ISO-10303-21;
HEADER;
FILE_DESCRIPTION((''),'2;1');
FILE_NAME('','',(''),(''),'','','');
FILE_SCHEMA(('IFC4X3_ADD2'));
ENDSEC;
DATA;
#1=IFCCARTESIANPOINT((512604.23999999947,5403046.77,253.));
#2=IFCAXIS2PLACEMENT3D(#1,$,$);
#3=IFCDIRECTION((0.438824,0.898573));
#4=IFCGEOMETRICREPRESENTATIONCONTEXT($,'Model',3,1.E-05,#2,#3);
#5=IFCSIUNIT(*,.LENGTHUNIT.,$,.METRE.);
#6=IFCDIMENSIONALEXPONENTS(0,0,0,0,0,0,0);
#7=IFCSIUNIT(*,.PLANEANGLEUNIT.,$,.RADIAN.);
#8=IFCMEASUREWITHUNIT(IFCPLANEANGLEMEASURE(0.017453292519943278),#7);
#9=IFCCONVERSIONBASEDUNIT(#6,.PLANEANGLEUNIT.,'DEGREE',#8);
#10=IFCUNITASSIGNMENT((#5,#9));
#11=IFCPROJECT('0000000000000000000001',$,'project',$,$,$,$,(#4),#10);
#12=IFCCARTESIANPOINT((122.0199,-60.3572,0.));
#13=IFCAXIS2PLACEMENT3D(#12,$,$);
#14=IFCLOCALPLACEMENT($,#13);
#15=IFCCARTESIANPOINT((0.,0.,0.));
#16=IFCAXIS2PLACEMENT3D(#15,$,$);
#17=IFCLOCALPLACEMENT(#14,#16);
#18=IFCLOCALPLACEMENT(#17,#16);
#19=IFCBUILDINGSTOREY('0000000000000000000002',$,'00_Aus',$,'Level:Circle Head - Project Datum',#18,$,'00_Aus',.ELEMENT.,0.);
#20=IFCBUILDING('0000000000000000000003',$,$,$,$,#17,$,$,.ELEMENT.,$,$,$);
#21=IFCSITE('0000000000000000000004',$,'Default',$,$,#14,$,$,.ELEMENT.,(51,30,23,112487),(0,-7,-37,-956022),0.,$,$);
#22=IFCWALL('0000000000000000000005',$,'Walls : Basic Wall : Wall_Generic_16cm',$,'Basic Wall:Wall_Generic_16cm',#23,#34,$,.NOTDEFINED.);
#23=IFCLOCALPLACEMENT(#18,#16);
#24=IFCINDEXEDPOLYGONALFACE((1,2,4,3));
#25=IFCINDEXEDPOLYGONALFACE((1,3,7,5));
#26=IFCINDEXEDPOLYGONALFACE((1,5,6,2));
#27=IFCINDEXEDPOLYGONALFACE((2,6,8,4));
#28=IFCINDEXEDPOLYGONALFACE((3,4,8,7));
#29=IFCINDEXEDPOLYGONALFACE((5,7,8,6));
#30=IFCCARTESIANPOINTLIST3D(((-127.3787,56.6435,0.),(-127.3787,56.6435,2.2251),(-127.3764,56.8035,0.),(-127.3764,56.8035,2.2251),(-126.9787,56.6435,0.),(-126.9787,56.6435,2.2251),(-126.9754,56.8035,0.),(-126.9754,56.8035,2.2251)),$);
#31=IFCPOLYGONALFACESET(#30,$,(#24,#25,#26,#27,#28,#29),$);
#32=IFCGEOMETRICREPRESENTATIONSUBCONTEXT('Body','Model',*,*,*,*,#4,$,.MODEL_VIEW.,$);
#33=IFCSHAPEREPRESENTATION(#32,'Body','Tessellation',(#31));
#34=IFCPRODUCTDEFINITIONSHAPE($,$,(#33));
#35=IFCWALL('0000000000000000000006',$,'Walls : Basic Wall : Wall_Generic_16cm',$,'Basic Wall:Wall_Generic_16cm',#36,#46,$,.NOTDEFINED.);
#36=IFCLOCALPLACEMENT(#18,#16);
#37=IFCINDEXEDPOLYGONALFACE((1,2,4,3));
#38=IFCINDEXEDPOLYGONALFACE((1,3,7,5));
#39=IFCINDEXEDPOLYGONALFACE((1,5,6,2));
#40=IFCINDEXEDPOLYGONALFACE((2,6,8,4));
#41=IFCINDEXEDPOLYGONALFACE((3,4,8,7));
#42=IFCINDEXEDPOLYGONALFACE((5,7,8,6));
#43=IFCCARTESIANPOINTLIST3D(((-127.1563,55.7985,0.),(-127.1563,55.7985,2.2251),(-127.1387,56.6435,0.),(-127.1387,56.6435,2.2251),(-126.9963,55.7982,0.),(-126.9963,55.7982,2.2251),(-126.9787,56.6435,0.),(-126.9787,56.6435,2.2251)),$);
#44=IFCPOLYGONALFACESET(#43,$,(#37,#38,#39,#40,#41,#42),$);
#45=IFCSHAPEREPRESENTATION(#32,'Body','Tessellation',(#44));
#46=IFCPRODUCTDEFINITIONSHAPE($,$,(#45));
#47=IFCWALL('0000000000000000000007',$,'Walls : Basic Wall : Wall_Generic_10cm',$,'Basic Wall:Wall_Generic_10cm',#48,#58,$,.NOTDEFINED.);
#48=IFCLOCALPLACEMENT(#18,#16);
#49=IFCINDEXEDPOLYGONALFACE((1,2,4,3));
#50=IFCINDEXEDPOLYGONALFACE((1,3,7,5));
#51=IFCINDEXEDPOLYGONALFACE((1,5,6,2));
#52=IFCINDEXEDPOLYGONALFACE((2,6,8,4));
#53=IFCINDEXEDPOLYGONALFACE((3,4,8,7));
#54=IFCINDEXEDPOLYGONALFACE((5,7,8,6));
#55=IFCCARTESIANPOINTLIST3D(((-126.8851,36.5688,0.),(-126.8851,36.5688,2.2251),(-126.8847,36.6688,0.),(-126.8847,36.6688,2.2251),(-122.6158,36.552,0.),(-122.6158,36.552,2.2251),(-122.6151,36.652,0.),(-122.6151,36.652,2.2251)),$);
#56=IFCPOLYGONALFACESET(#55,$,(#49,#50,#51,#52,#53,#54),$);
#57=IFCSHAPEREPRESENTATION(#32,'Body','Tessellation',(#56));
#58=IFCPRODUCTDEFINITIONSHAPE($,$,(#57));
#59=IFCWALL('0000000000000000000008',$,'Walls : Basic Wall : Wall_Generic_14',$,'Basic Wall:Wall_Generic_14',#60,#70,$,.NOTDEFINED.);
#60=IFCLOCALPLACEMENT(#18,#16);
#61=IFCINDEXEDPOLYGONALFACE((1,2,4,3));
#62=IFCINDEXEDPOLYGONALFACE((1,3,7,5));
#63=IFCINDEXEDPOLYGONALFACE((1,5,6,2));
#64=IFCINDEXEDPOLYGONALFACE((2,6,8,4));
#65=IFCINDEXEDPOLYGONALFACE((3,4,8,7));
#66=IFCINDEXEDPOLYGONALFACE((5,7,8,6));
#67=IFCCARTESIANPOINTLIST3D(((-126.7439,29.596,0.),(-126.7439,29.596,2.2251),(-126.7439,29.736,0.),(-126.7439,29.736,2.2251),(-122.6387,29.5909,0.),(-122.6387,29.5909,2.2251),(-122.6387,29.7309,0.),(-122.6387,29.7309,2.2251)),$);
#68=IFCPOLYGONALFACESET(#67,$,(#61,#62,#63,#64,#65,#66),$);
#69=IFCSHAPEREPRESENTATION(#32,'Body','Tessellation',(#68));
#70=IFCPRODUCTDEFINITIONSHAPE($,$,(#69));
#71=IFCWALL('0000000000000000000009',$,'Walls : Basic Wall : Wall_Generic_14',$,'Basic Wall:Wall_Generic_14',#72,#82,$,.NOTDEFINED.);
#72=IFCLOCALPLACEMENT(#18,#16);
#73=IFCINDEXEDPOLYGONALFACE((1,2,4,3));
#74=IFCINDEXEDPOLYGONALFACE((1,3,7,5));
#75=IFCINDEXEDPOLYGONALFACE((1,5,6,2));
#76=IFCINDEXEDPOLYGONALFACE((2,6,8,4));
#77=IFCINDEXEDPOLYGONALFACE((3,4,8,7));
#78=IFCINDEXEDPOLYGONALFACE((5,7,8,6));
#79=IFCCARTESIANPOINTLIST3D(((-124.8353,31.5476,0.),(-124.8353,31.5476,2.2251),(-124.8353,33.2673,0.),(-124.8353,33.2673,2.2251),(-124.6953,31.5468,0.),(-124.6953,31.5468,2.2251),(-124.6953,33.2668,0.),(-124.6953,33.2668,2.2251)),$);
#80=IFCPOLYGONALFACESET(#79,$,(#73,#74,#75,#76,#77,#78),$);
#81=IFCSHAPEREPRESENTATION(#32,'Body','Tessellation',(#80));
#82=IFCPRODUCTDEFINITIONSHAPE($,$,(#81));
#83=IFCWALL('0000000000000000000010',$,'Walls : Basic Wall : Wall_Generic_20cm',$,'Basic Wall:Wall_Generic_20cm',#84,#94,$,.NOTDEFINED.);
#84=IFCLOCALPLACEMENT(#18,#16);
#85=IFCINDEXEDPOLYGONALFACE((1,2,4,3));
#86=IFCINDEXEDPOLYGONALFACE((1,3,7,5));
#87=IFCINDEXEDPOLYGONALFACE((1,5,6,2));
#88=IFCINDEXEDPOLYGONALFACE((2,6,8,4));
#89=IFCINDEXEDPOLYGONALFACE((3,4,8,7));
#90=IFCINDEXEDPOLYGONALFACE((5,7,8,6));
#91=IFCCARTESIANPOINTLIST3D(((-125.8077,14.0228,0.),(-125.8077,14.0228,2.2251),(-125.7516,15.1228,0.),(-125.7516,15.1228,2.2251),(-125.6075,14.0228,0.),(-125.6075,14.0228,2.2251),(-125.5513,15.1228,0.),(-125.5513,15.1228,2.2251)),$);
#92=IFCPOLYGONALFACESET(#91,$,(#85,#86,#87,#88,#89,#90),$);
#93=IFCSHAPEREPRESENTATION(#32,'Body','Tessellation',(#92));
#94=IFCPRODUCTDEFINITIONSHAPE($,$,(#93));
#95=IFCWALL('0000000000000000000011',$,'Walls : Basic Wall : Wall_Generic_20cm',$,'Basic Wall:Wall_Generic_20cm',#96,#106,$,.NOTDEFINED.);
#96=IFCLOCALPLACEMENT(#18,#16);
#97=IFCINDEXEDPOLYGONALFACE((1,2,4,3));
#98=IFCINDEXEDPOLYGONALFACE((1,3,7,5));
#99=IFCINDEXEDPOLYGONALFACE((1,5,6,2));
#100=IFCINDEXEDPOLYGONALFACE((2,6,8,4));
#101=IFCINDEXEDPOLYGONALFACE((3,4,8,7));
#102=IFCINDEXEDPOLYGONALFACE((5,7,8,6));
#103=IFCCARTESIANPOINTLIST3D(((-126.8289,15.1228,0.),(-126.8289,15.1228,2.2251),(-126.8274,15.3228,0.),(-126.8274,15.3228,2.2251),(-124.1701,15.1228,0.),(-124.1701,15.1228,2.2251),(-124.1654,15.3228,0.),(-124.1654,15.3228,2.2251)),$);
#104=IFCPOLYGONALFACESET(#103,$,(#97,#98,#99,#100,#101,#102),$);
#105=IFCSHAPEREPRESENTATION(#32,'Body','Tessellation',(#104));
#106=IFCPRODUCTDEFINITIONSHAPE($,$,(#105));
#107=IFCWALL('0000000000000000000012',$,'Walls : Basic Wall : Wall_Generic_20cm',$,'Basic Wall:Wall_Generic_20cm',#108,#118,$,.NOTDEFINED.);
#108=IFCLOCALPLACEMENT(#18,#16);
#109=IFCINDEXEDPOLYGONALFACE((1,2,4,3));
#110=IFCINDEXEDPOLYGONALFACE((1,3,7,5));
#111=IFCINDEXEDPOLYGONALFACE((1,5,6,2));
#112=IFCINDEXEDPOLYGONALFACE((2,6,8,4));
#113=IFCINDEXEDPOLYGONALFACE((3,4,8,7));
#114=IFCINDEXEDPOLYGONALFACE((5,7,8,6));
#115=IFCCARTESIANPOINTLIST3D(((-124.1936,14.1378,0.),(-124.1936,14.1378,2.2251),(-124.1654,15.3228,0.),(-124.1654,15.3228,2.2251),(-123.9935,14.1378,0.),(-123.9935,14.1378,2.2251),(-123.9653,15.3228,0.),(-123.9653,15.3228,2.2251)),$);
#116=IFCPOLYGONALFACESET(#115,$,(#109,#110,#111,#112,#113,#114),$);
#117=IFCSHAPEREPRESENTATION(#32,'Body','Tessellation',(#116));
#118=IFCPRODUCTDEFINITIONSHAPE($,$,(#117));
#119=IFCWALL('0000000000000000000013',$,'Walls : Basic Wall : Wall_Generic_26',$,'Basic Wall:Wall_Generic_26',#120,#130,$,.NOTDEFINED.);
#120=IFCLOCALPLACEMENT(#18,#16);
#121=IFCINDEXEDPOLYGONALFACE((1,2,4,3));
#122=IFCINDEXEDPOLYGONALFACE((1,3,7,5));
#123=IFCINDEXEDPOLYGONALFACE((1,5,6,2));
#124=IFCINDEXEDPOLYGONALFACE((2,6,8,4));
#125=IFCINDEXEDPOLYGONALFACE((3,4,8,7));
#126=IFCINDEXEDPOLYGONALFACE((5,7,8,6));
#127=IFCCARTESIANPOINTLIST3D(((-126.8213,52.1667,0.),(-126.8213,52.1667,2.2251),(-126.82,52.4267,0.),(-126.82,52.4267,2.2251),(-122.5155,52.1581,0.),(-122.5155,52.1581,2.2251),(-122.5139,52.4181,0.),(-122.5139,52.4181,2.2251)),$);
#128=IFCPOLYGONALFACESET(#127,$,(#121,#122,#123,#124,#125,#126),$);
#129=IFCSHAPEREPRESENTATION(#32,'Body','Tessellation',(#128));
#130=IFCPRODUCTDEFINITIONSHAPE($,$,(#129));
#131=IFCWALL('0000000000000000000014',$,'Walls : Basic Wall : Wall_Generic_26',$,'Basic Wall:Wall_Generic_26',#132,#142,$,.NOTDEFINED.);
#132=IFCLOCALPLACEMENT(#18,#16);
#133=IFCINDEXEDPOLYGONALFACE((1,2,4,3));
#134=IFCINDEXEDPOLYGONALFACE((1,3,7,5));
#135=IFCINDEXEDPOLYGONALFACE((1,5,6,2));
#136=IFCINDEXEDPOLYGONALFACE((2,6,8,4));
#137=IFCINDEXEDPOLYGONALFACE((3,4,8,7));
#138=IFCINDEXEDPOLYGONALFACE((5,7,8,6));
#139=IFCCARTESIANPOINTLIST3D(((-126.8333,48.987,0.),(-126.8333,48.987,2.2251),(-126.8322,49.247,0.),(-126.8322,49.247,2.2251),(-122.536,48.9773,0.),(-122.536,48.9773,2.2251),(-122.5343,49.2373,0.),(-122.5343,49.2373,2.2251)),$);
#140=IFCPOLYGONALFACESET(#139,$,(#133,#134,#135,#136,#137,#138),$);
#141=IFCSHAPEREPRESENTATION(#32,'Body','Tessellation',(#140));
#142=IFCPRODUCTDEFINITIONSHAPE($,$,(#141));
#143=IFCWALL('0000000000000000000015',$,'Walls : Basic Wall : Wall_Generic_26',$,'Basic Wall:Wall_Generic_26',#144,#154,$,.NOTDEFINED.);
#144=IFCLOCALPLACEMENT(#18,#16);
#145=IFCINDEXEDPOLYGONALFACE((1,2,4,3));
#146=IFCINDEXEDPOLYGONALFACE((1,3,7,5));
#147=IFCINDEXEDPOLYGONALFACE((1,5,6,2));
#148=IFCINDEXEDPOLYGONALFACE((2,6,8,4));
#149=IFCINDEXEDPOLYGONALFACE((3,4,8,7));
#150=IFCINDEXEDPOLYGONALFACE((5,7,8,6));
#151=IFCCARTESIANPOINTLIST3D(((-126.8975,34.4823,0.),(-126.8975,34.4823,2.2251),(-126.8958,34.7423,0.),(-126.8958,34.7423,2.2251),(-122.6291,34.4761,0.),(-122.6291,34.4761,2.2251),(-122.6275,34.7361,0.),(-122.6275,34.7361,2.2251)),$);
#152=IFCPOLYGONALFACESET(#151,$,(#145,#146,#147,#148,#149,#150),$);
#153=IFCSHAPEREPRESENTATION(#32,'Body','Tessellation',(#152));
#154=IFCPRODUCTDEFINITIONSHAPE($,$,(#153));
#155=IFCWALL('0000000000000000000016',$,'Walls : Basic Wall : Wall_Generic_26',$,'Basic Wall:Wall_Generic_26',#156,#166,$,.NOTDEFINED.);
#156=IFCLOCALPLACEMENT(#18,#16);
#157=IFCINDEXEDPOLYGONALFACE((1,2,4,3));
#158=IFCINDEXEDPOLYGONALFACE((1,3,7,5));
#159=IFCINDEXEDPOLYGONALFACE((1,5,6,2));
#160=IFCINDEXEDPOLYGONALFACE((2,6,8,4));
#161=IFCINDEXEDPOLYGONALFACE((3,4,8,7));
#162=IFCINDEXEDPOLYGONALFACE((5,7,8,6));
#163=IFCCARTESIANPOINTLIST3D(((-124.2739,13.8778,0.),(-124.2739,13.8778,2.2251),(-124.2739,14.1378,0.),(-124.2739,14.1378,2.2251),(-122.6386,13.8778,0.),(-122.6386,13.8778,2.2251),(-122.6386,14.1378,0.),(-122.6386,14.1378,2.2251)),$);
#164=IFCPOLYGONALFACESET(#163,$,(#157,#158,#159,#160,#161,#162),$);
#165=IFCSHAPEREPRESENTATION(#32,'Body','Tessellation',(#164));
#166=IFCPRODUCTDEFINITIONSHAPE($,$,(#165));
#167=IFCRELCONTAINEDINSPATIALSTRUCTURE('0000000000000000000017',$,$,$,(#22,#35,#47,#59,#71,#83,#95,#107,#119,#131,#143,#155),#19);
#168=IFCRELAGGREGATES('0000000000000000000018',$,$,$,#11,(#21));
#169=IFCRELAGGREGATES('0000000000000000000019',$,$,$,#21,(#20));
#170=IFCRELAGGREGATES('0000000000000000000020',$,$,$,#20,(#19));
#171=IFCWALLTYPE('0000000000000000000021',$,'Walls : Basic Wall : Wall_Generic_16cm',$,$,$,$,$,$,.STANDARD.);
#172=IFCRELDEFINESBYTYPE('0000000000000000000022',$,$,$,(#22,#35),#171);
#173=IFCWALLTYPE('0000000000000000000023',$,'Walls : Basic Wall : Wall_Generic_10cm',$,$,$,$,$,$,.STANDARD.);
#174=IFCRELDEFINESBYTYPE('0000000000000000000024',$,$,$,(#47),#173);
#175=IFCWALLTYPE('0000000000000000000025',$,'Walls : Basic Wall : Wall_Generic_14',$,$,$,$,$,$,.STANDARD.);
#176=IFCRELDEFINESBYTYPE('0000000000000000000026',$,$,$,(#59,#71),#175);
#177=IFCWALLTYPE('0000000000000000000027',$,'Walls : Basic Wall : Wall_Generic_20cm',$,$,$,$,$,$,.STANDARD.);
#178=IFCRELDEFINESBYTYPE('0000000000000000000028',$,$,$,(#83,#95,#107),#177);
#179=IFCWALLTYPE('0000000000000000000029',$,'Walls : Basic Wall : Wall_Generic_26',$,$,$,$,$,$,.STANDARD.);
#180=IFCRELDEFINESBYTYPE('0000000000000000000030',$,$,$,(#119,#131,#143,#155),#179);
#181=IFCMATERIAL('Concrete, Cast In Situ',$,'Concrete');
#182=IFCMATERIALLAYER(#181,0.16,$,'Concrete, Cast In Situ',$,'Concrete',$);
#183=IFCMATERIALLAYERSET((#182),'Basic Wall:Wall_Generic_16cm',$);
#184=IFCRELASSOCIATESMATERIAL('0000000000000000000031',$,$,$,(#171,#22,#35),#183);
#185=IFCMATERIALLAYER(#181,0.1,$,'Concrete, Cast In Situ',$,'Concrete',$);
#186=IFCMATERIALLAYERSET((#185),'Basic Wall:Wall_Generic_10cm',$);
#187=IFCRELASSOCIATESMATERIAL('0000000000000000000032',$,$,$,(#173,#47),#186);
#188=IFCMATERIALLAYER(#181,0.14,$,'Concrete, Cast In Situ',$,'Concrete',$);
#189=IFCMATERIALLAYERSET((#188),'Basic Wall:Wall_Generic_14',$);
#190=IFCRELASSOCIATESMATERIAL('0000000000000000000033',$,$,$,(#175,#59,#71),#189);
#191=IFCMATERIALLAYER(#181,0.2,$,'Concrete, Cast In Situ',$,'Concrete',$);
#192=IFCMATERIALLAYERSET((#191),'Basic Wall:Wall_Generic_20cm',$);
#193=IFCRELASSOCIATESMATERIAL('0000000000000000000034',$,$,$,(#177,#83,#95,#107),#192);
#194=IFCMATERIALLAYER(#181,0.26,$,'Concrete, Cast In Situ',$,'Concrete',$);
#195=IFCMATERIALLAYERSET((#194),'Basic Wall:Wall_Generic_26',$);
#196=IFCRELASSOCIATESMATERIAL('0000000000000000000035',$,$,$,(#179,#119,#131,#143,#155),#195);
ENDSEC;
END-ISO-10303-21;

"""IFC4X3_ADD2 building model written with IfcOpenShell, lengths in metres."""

from ifc_helpers import new_model, entity, si_unit, converted_unit, direction, frame, origin, place, context, subcontext, project, spatial, polyline, outline, extrude, clip, halfspace, material, layer, layer_set, type_object, element, save


model = new_model("IFC4X3_ADD2")

# Units and contexts
model_context = context("Model", 3, precision=1e-05, world=frame((512604.23999999947, 5403046.77, 253.0)), true_north=direction((0.438824, 0.898573)))
body_context = subcontext(model_context, "Body", "Model", "MODEL_VIEW")
ifc_project = project(units=[si_unit("LENGTHUNIT", "METRE"), converted_unit("PLANEANGLEUNIT", "DEGREE", entity("IfcPlaneAngleMeasure", 0.017453292519943278), si_unit("PLANEANGLEUNIT", "RADIAN"), dimensions=[0, 0, 0, 0, 0, 0, 0])], contexts=[model_context])

# Site, building, storey
site_placement = place(None, frame((122.0199, -60.3572, 0.0)))
site = spatial("IfcSite", under=ifc_project, at=site_placement, Name="Default", CompositionType="ELEMENT", RefLatitude=(51, 30, 23, 112487), RefLongitude=(0, -7, -37, -956022), RefElevation=0.0)
building_placement = place(site_placement, origin())
building = spatial("IfcBuilding", under=site, at=building_placement, CompositionType="ELEMENT")
storey_placement = place(building_placement, origin())
storey = spatial("IfcBuildingStorey", under=building, at=storey_placement, Name="00_Aus", ObjectType="Level:Circle Head - Project Datum", LongName="00_Aus", CompositionType="ELEMENT", Elevation=0.0)

# Shared definitions
ifc_material_1 = material(Name="Concrete, Cast In Situ", Category="Concrete")

# Walls
ifc_layer_1 = layer(ifc_material_1, 0.16, Name="Concrete, Cast In Situ", Category="Concrete")
ifc_layer_set_1 = layer_set([ifc_layer_1], Name="Basic Wall:Wall_Generic_16cm")
wall_type_1 = type_object("IfcWallType", Name="Walls : Basic Wall : Wall_Generic_16cm", PredefinedType="STANDARD", material=ifc_layer_set_1)
wall_1_placement = place(storey_placement, frame((-127.3787, 56.7235, 0.0)))
element("IfcWall", 1, at=wall_1_placement, inside=storey, type_object=wall_type_1, material=ifc_layer_set_1, Name="Walls : Basic Wall : Wall_Generic_16cm", ObjectType="Basic Wall:Wall_Generic_16cm", PredefinedType="NOTDEFINED", context=body_context, shape_type="Clipping", body=[
    clip(extrude(outline(polyline([(0.4, -0.08), (0.4034, 0.08), (0.1623, 0.08), (0.0023, 0.08), (0.0011, -0.0029), (0.0, -0.08), (0.24, -0.08), (0.4, -0.08)])), origin(), (0.0, 0.0, 1.0), 2.2251), halfspace(frame((0.0, 0.0, -0.66)), True)),
])
wall_2_placement = place(storey_placement, frame((-127.0587, 56.6452, 0.0), z_axis=(0.0, 0.0, 1.0), x_axis=(-0.020814, -0.999783, 0.0)))
element("IfcWall", 2, at=wall_2_placement, inside=storey, type_object=wall_type_1, material=ifc_layer_set_1, Name="Walls : Basic Wall : Wall_Generic_16cm", ObjectType="Basic Wall:Wall_Generic_16cm", PredefinedType="NOTDEFINED", context=body_context, shape_type="Clipping", body=[
    clip(extrude(outline(polyline([(0.8485, -0.08), (0.8455, 0.08), (0.0, 0.08), (0.0033, -0.08), (0.8485, -0.08)])), origin(), (0.0, 0.0, 1.0), 2.2251), halfspace(frame((0.0, 0.0, -0.66)), True)),
])
ifc_layer_2 = layer(ifc_material_1, 0.1, Name="Concrete, Cast In Situ", Category="Concrete")
ifc_layer_set_2 = layer_set([ifc_layer_2], Name="Basic Wall:Wall_Generic_10cm")
wall_type_2 = type_object("IfcWallType", Name="Walls : Basic Wall : Wall_Generic_10cm", PredefinedType="STANDARD", material=ifc_layer_set_2)
wall_3_placement = place(storey_placement, frame((-126.8849, 36.6188, 0.0), z_axis=(0.0, 0.0, 1.0), x_axis=(0.999992, -0.003937, 0.0)))
element("IfcWall", 3, at=wall_3_placement, inside=storey, type_object=wall_type_2, material=ifc_layer_set_2, Name="Walls : Basic Wall : Wall_Generic_10cm", ObjectType="Basic Wall:Wall_Generic_10cm", PredefinedType="NOTDEFINED", context=body_context, shape_type="Clipping", body=[
    clip(extrude(outline(polyline([(4.2694, -0.05), (4.2696, 0.05), (0.0, 0.05), (0.0, -0.05), (2.7103, -0.05), (2.8303, -0.05), (4.2694, -0.05)])), origin(), (0.0, 0.0, 1.0), 2.2251), halfspace(frame((0.0, 0.0, -0.66)), True)),
])
ifc_layer_3 = layer(ifc_material_1, 0.14, Name="Concrete, Cast In Situ", Category="Concrete")
ifc_layer_set_3 = layer_set([ifc_layer_3], Name="Basic Wall:Wall_Generic_14")
wall_type_3 = type_object("IfcWallType", Name="Walls : Basic Wall : Wall_Generic_14", PredefinedType="STANDARD", material=ifc_layer_set_3)
wall_4_placement = place(storey_placement, frame((-122.6386, 29.6609, 0.0), z_axis=(0.0, 0.0, 1.0), x_axis=(-0.999999, 0.001241, 0.0)))
element("IfcWall", 4, at=wall_4_placement, inside=storey, type_object=wall_type_3, material=ifc_layer_set_3, Name="Walls : Basic Wall : Wall_Generic_14", ObjectType="Basic Wall:Wall_Generic_14", PredefinedType="NOTDEFINED", context=body_context, shape_type="Clipping", body=[
    clip(extrude(outline(polyline([(4.1054, -0.07), (4.1052, 0.07), (0.0, 0.07), (0.0002, -0.07), (1.0052, -0.07), (1.1652, -0.07), (2.3156, -0.07), (2.3556, -0.07), (4.1054, -0.07)])), origin(), (0.0, 0.0, 1.0), 2.2251), halfspace(frame((0.0, 0.0, -0.66)), True)),
])
wall_5_placement = place(storey_placement, frame((-124.7653, 31.5468, 0.0), z_axis=(0.0, 0.0, 1.0), x_axis=(0.0, 1.0, 0.0)))
element("IfcWall", 5, at=wall_5_placement, inside=storey, type_object=wall_type_3, material=ifc_layer_set_3, Name="Walls : Basic Wall : Wall_Generic_14", ObjectType="Basic Wall:Wall_Generic_14", PredefinedType="NOTDEFINED", context=body_context, shape_type="Clipping", body=[
    clip(extrude(outline(polyline([(1.72, -0.07), (1.7205, 0.07), (1.6005, 0.07), (0.0008, 0.07), (0.0, -0.07), (1.72, -0.07)])), origin(), (0.0, 0.0, 1.0), 2.2251), halfspace(frame((0.0, 0.0, -0.66)), True)),
])
ifc_layer_4 = layer(ifc_material_1, 0.2, Name="Concrete, Cast In Situ", Category="Concrete")
ifc_layer_set_4 = layer_set([ifc_layer_4], Name="Basic Wall:Wall_Generic_20cm")
wall_type_4 = type_object("IfcWallType", Name="Walls : Basic Wall : Wall_Generic_20cm", PredefinedType="STANDARD", material=ifc_layer_set_4)
wall_6_placement = place(storey_placement, frame((-125.7078, 14.0177, 0.0), z_axis=(0.0, 0.0, 1.0), x_axis=(0.050959, 0.998701, 0.0)))
element("IfcWall", 6, at=wall_6_placement, inside=storey, type_object=wall_type_4, material=ifc_layer_set_4, Name="Walls : Basic Wall : Wall_Generic_20cm", ObjectType="Basic Wall:Wall_Generic_20cm", PredefinedType="NOTDEFINED", context=body_context, shape_type="Clipping", body=[
    clip(extrude(outline(polyline([(1.1116, -0.1), (1.1014, 0.1), (0.0, 0.1), (0.0102, -0.1), (0.7375, -0.1), (1.1116, -0.1)])), origin(), (0.0, 0.0, 1.0), 2.2251), halfspace(frame((0.0, 0.0, -0.66)), True)),
])
wall_7_placement = place(storey_placement, frame((-126.8289, 15.2228, 0.0)))
element("IfcWall", 7, at=wall_7_placement, inside=storey, type_object=wall_type_4, material=ifc_layer_set_4, Name="Walls : Basic Wall : Wall_Generic_20cm", ObjectType="Basic Wall:Wall_Generic_20cm", PredefinedType="NOTDEFINED", context=body_context, shape_type="Clipping", body=[
    clip(extrude(outline(polyline([(2.6587, -0.1), (2.6635, 0.1), (0.0015, 0.1), (0.0, -0.1), (1.0773, -0.1), (1.2775, -0.1), (2.6587, -0.1)])), origin(), (0.0, 0.0, 1.0), 2.2251), halfspace(frame((0.0, 0.0, -0.66)), True)),
])
wall_8_placement = place(storey_placement, frame((-124.0653, 15.3252, 0.0), z_axis=(0.0, 0.0, 1.0), x_axis=(-0.023777, -0.999717, 0.0)))
element("IfcWall", 8, at=wall_8_placement, inside=storey, type_object=wall_type_4, material=ifc_layer_set_4, Name="Walls : Basic Wall : Wall_Generic_20cm", ObjectType="Basic Wall:Wall_Generic_20cm", PredefinedType="NOTDEFINED", context=body_context, shape_type="Clipping", body=[
    clip(extrude(outline(polyline([(1.19, -0.1), (1.1853, 0.1), (0.0, 0.1), (0.0048, -0.1), (0.2048, -0.1), (0.5785, -0.1), (1.19, -0.1)])), origin(), (0.0, 0.0, 1.0), 2.2251), halfspace(frame((0.0, 0.0, -0.66)), True)),
])
ifc_layer_5 = layer(ifc_material_1, 0.26, Name="Concrete, Cast In Situ", Category="Concrete")
ifc_layer_set_5 = layer_set([ifc_layer_5], Name="Basic Wall:Wall_Generic_26")
wall_type_5 = type_object("IfcWallType", Name="Walls : Basic Wall : Wall_Generic_26", PredefinedType="STANDARD", material=ifc_layer_set_5)
wall_9_placement = place(storey_placement, frame((-126.8211, 52.2967, 0.0), z_axis=(0.0, 0.0, 1.0), x_axis=(0.999998, -0.002005, 0.0)))
element("IfcWall", 9, at=wall_9_placement, inside=storey, type_object=wall_type_5, material=ifc_layer_set_5, Name="Walls : Basic Wall : Wall_Generic_26", ObjectType="Basic Wall:Wall_Generic_26", PredefinedType="NOTDEFINED", context=body_context, shape_type="Clipping", body=[
    clip(extrude(outline(polyline([(4.3058, -0.13), (4.3069, 0.13), (0.0008, 0.13), (0.0, -0.13), (0.0013, -0.13), (4.3058, -0.13)])), origin(), (0.0, 0.0, 1.0), 2.2251), halfspace(frame((0.0, 0.0, -0.66)), True)),
])
wall_10_placement = place(storey_placement, frame((-122.5346, 49.1073, 0.0), z_axis=(0.0, 0.0, 1.0), x_axis=(-0.999997, 0.002248, 0.0)))
element("IfcWall", 10, at=wall_10_placement, inside=storey, type_object=wall_type_5, material=ifc_layer_set_5, Name="Walls : Basic Wall : Wall_Generic_26", ObjectType="Basic Wall:Wall_Generic_26", PredefinedType="NOTDEFINED", context=body_context, shape_type="Clipping", body=[
    clip(extrude(outline(polyline([(4.298, -0.13), (4.2985, 0.13), (0.0011, 0.13), (0.0, -0.13), (4.298, -0.13)])), origin(), (0.0, 0.0, 1.0), 2.2251), halfspace(frame((0.0, 0.0, -0.66)), True)),
])
wall_11_placement = place(storey_placement, frame((-122.6276, 34.6061, 0.0), z_axis=(0.0, 0.0, 1.0), x_axis=(-0.999999, 0.001453, 0.0)))
element("IfcWall", 11, at=wall_11_placement, inside=storey, type_object=wall_type_5, material=ifc_layer_set_5, Name="Walls : Basic Wall : Wall_Generic_26", ObjectType="Basic Wall:Wall_Generic_26", PredefinedType="NOTDEFINED", context=body_context, shape_type="Clipping", body=[
    clip(extrude(outline(polyline([(4.2683, -0.13), (4.2697, 0.13), (0.0013, 0.13), (0.0, -0.13), (1.438, -0.13), (1.558, -0.13), (4.2683, -0.13)])), origin(), (0.0, 0.0, 1.0), 2.2251), halfspace(frame((0.0, 0.0, -0.66)), True)),
])
wall_12_placement = place(storey_placement, frame((-122.6386, 14.0078, 0.0), z_axis=(0.0, 0.0, 1.0), x_axis=(-1.0, 0.0, 0.0)))
element("IfcWall", 12, at=wall_12_placement, inside=storey, type_object=wall_type_5, material=ifc_layer_set_5, Name="Walls : Basic Wall : Wall_Generic_26", ObjectType="Basic Wall:Wall_Generic_26", PredefinedType="NOTDEFINED", context=body_context, shape_type="Clipping", body=[
    clip(extrude(outline(polyline([(1.6352, -0.13), (1.6352, 0.13), (0.0, 0.13), (0.0, -0.13), (1.3549, -0.13), (1.555, -0.13), (1.6352, -0.13)])), origin(), (0.0, 0.0, 1.0), 2.2251), halfspace(frame((0.0, 0.0, -0.66)), True)),
])

save(model, "model.ifc")
